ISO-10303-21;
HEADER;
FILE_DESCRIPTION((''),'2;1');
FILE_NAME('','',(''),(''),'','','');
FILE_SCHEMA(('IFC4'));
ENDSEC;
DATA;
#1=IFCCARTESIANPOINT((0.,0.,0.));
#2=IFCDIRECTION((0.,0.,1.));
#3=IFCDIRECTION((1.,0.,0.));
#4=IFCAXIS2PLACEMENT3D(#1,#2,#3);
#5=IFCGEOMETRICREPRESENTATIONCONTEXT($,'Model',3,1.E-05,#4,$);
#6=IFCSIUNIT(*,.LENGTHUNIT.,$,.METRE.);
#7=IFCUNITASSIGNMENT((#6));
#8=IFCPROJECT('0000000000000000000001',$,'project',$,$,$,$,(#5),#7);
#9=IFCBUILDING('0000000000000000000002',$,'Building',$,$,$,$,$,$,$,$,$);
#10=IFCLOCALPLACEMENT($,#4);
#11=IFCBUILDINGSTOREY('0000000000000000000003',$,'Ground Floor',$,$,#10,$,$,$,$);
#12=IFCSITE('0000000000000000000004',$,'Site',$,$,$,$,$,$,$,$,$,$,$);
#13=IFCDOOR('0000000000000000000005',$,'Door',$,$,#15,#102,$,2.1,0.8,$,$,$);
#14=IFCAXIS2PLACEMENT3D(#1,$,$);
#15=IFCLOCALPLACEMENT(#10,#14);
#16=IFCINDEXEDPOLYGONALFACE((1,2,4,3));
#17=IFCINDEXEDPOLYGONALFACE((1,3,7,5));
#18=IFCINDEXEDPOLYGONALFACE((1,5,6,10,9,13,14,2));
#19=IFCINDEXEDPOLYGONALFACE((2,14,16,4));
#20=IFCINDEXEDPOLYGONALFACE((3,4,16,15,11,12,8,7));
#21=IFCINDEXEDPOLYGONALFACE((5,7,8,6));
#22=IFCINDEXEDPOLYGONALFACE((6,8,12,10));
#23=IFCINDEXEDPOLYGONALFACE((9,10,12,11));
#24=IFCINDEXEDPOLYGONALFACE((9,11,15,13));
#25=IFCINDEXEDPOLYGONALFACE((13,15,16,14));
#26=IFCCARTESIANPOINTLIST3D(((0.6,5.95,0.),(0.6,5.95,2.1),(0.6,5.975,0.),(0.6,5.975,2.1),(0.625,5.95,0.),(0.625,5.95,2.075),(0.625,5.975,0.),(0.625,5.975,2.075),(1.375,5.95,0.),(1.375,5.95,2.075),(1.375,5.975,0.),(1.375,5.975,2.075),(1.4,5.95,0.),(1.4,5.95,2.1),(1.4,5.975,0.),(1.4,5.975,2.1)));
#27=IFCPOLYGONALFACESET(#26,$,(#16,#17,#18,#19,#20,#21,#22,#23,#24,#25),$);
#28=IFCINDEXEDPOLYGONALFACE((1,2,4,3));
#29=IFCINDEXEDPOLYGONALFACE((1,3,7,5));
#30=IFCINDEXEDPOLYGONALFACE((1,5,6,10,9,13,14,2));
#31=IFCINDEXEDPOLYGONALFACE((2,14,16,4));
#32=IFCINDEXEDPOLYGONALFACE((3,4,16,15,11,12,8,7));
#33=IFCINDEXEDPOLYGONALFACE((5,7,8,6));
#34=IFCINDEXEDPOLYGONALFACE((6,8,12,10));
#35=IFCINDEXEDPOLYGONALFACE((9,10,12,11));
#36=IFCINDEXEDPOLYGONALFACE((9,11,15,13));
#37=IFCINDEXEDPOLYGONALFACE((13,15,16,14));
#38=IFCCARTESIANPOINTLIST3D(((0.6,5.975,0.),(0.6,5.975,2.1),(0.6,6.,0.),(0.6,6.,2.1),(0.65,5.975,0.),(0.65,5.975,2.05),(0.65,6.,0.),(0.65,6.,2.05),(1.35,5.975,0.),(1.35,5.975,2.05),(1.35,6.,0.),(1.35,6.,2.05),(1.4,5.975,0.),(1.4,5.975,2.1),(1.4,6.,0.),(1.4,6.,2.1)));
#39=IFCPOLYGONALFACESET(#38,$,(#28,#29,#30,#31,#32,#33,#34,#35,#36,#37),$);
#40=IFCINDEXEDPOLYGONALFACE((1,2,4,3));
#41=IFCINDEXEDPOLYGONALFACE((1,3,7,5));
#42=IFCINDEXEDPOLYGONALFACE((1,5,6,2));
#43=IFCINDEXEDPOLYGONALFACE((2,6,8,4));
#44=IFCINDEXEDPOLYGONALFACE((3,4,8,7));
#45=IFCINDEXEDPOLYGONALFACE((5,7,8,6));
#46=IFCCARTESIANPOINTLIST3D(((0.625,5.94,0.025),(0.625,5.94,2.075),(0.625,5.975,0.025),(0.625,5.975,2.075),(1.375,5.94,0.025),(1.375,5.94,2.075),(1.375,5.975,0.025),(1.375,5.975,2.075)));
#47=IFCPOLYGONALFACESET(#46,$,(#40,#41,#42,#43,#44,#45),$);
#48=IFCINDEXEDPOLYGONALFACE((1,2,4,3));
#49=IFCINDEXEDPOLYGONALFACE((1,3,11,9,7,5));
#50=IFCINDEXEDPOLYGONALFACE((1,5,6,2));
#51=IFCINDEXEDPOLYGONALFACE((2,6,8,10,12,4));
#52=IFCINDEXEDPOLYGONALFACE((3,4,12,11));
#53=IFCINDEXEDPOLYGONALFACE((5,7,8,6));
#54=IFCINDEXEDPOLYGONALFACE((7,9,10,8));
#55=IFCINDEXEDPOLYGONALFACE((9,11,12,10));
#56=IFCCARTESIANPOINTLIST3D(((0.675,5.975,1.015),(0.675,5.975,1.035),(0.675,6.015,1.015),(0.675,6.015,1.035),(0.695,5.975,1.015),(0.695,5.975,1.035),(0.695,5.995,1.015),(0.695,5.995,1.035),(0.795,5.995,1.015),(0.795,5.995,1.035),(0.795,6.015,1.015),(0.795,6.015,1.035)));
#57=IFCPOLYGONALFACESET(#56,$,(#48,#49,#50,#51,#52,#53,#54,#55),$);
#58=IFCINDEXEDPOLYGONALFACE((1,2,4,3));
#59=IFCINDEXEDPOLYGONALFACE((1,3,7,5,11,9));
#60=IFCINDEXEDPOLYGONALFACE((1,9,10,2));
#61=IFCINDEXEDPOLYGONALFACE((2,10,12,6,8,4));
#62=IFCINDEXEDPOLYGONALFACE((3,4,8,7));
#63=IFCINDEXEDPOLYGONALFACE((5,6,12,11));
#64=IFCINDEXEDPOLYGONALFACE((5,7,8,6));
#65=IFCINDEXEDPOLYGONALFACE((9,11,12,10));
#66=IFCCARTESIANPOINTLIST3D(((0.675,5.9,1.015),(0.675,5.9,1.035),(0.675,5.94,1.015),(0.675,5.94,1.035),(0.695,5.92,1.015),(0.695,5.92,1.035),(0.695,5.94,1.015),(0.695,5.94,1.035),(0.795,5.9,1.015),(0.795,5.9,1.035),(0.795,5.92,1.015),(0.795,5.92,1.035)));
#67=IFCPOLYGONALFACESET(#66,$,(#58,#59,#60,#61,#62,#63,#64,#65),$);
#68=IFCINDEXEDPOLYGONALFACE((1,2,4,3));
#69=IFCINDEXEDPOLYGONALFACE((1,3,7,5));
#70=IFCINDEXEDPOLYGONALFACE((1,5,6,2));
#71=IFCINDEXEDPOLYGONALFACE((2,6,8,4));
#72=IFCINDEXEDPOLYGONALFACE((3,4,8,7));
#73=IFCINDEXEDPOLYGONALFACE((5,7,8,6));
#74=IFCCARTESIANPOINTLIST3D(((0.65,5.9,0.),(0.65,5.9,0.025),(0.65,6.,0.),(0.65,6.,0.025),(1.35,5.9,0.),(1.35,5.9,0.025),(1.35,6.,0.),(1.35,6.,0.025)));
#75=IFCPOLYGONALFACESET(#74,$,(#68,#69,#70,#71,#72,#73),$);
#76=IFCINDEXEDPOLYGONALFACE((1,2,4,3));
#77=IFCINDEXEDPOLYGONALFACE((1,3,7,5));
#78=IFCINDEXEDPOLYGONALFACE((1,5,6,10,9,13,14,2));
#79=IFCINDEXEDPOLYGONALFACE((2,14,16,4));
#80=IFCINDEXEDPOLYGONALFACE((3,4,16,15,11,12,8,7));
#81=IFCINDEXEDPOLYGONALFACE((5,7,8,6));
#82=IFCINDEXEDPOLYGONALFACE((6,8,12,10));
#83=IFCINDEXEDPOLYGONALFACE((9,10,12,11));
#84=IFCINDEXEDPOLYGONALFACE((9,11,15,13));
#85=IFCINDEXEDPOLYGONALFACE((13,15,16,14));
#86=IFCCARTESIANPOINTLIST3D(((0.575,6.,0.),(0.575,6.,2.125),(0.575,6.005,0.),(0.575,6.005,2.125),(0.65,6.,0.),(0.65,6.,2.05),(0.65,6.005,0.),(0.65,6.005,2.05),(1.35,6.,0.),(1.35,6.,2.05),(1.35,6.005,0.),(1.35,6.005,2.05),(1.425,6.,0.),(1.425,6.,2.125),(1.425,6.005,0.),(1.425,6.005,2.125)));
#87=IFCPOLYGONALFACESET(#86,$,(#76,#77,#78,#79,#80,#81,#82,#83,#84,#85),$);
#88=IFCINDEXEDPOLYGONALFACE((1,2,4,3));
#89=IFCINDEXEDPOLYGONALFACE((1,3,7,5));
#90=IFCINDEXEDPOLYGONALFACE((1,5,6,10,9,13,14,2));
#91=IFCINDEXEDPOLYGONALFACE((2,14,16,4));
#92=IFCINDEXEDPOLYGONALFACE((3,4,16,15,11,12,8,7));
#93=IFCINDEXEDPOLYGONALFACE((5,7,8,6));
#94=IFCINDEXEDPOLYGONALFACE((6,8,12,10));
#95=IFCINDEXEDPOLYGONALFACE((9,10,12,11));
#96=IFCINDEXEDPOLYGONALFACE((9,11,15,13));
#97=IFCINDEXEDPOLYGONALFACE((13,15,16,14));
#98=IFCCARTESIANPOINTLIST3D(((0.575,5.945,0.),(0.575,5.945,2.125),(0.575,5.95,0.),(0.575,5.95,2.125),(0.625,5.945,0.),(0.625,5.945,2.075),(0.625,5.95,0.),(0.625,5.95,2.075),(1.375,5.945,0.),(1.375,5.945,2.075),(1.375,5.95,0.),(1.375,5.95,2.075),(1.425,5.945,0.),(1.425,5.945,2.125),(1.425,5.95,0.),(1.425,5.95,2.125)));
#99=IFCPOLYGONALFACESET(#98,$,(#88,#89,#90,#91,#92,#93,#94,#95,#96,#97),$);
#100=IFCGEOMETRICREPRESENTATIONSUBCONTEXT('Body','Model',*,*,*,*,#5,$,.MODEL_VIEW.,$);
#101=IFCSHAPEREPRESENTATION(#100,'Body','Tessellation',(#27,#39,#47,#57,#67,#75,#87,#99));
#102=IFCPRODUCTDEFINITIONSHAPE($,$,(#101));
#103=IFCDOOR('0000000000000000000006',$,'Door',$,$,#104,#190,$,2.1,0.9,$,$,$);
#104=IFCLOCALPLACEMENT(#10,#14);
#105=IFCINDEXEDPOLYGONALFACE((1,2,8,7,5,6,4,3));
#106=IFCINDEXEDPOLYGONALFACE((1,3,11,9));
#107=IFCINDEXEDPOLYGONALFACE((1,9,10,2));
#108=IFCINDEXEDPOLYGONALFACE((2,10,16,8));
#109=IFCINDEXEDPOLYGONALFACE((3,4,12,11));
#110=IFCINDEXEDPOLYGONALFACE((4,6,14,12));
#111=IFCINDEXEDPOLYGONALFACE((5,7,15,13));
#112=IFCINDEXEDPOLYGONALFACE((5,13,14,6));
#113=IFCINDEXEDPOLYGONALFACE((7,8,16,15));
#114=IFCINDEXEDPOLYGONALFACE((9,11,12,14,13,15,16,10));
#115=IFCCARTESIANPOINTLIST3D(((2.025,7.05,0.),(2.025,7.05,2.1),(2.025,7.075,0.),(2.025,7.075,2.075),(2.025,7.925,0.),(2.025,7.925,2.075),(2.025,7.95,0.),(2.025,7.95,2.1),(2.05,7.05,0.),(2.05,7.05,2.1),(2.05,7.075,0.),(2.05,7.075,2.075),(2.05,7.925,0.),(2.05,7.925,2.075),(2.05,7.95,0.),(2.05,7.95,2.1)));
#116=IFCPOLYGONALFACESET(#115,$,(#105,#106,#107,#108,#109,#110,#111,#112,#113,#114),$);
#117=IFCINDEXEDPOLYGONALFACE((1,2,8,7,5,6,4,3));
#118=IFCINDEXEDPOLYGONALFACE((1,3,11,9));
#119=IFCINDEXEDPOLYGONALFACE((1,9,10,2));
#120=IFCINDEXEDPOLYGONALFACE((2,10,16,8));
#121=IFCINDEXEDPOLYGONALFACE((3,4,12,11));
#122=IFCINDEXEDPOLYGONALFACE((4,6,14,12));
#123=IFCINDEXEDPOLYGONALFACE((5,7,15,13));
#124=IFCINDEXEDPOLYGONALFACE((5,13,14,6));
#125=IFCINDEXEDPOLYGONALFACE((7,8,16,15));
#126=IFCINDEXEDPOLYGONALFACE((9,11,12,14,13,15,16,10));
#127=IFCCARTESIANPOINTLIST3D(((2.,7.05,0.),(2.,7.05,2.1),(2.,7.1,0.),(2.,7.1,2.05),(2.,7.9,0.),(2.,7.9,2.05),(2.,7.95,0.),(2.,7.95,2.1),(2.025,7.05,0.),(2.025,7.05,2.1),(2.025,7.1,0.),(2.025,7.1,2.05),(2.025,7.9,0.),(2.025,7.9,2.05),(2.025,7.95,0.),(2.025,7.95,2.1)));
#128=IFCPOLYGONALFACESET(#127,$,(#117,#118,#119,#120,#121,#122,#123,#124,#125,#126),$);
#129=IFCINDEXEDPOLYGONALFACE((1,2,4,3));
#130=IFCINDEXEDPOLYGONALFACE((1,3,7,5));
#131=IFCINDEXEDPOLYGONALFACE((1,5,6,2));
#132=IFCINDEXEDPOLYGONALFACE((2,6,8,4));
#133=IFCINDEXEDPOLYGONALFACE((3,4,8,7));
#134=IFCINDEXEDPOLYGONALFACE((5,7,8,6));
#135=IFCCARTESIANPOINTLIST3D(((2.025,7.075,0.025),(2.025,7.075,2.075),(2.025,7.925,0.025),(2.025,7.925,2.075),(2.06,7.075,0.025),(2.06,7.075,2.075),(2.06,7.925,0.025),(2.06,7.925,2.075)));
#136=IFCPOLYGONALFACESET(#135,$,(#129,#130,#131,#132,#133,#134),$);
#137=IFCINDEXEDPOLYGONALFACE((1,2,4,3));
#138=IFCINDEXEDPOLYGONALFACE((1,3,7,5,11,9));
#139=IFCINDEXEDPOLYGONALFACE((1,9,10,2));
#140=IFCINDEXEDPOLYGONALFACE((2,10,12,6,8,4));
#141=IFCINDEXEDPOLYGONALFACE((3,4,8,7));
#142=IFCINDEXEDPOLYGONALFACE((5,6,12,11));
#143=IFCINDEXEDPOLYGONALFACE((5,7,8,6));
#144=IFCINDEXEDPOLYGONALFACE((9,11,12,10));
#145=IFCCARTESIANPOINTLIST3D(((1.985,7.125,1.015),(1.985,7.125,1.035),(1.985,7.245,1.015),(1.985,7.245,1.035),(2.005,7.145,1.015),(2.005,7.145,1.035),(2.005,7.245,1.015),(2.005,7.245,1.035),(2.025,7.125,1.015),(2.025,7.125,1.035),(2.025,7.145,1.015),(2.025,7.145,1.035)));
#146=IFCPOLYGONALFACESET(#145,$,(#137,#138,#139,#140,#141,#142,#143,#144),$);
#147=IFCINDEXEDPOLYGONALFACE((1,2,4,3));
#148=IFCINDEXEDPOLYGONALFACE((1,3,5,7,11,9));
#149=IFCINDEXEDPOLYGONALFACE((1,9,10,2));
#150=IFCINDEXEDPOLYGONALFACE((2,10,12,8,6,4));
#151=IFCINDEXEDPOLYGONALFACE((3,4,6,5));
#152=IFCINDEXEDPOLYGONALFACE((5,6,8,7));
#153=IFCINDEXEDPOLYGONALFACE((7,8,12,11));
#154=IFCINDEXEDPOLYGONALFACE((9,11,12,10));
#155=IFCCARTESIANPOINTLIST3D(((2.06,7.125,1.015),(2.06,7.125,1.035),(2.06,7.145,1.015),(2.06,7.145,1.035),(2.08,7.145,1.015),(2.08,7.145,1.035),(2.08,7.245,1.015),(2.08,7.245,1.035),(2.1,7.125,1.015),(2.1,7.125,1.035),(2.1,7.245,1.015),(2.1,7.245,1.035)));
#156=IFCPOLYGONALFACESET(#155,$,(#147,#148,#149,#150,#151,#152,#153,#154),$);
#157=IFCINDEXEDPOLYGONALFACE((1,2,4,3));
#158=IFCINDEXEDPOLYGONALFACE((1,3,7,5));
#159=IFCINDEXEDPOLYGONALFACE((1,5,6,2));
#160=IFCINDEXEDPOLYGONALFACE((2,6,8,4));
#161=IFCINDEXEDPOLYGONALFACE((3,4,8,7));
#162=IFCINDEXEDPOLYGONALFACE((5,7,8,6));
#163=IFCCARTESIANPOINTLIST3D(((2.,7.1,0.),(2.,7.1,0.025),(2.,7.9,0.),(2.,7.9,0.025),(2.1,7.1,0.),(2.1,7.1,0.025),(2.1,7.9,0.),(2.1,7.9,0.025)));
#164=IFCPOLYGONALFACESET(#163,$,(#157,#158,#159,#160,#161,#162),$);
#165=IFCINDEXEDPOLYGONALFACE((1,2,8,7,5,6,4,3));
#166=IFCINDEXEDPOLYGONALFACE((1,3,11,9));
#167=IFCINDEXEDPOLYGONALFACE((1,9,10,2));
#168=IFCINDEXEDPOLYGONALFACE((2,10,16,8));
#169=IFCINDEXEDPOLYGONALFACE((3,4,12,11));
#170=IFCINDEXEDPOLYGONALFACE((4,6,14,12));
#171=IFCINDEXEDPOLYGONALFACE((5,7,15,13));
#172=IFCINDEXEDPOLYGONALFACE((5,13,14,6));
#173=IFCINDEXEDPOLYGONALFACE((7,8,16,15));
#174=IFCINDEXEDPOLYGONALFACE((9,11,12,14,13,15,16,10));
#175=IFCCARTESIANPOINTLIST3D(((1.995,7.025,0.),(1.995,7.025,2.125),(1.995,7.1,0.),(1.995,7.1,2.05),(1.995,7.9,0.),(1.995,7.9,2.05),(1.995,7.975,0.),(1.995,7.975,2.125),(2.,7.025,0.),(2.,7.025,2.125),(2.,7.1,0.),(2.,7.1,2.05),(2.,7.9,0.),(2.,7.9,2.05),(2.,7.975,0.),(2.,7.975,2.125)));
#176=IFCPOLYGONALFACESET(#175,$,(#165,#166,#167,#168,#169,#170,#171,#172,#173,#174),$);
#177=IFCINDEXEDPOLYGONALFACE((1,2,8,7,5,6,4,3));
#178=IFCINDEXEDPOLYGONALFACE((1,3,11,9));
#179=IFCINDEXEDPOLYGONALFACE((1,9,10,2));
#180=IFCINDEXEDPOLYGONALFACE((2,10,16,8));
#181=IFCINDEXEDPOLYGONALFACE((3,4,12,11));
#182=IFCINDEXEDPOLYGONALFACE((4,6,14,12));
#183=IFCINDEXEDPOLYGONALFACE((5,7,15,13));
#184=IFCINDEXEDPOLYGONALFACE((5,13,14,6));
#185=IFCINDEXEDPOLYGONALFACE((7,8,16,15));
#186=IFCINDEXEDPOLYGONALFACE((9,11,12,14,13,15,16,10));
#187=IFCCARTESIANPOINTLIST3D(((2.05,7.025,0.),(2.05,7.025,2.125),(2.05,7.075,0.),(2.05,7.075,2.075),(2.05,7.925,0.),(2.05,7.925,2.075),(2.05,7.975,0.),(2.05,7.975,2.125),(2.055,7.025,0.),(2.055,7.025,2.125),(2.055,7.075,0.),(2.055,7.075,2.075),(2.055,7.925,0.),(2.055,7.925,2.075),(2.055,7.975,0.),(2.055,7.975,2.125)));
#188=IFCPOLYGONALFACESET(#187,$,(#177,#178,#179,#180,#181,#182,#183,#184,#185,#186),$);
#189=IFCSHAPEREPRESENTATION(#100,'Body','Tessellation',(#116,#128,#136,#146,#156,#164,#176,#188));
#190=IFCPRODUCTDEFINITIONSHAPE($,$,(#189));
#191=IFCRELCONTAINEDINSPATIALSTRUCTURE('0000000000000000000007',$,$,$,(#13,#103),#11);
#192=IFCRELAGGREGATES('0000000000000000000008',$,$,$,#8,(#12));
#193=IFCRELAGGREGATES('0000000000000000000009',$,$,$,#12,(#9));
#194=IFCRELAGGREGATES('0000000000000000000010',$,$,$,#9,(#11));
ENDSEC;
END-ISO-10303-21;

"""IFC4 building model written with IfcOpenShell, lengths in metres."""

from ifc_helpers import new_model, si_unit, frame, origin_with_axes, place, context, subcontext, project, spatial, line, indexed_curve, outline, extrude, element, save


model = new_model("IFC4")

# Units and contexts
model_context = context("Model", 3, precision=1e-05, world=origin_with_axes())
body_context = subcontext(model_context, "Body", "Model", "MODEL_VIEW")
ifc_project = project(units=[si_unit("LENGTHUNIT", "METRE")], contexts=[model_context])

# Site, building, storey
site = spatial("IfcSite", under=ifc_project, Name="Site")
building = spatial("IfcBuilding", under=site, Name="Building")
storey_placement = place(None, origin_with_axes())
storey = spatial("IfcBuildingStorey", under=building, at=storey_placement, Name="Ground Floor")

# Doors
door_1_placement = place(storey_placement, frame((1.4, 6.0, 0.0), z_axis=(0.0, 0.0, 1.0), x_axis=(-1.0, 0.0, 0.0)))
element("IfcDoor", 1, at=door_1_placement, inside=storey, Name="Door", OverallHeight=2.1, OverallWidth=0.8, context=body_context, shape_type="SweptSolid", body=[
    extrude(outline(indexed_curve([(0.0, 0.0), (0.0, 2.1), (0.8, 2.1), (0.8, 0.0), (0.775, 0.0), (0.775, 2.075), (0.025, 2.075), (0.025, 0.0)], segments=[line(1, 2, 3, 4, 5, 6, 7, 8, 1)])), frame((0.0, 0.025, 0.0), z_axis=(0.0, -1.0, 0.0), x_axis=(1.0, 0.0, 0.0)), (0.0, 0.0, -1.0), 0.025),
    extrude(outline(indexed_curve([(0.0, 0.0), (0.0, 2.1), (0.8, 2.1), (0.8, 0.0), (0.75, 0.0), (0.75, 2.05), (0.05, 2.05), (0.05, 0.0)], segments=[line(1, 2, 3, 4, 5, 6, 7, 8, 1)])), frame((0.0, 0.0, 0.0), z_axis=(0.0, -1.0, 0.0), x_axis=(1.0, 0.0, 0.0)), (0.0, 0.0, -1.0), 0.025),
    extrude(outline(indexed_curve([(0.0, 0.0), (0.75, 0.0), (0.75, 0.035), (0.0, 0.035)], segments=[line(1, 2, 3, 4, 1)])), frame((0.025, 0.025, 0.025), z_axis=(0.0, 0.0, 1.0), x_axis=(1.0, 0.0, 0.0)), (0.0, 0.0, 1.0), 2.05),
    extrude(outline(indexed_curve([(0.0, 0.0), (0.0, -0.04), (-0.12, -0.04), (-0.12, -0.02), (-0.02, -0.02), (-0.02, 0.0)], segments=[line(1, 2, 3, 4, 5, 6, 1)])), frame((0.725, 0.025, 1.015), z_axis=(0.0, 0.0, 1.0), x_axis=(1.0, 0.0, 0.0)), (0.0, 0.0, 1.0), 0.02),
    extrude(outline(indexed_curve([(0.0, 0.0), (0.0, 0.04), (-0.12, 0.04), (-0.12, 0.02), (-0.02, 0.02), (-0.02, 0.0)], segments=[line(1, 2, 3, 4, 5, 6, 1)])), frame((0.725, 0.06, 1.015), z_axis=(0.0, 0.0, 1.0), x_axis=(1.0, 0.0, 0.0)), (0.0, 0.0, 1.0), 0.02),
    extrude(outline(indexed_curve([(0.0, 0.0), (0.7, 0.0), (0.7, 0.1), (0.0, 0.1)], segments=[line(1, 2, 3, 4, 1)])), frame((0.05, 0.0, 0.0), z_axis=(0.0, 0.0, 1.0), x_axis=(1.0, 0.0, 0.0)), (0.0, 0.0, 1.0), 0.025),
    extrude(outline(indexed_curve([(0.0, 0.0), (0.0, 2.125), (0.85, 2.125), (0.85, 0.0), (0.775, 0.0), (0.775, 2.05), (0.075, 2.05), (0.075, 0.0)], segments=[line(1, 2, 3, 4, 5, 6, 7, 8, 1)])), frame((-0.025, -0.005, 0.0), z_axis=(0.0, -1.0, 0.0), x_axis=(1.0, 0.0, 0.0)), (0.0, 0.0, -1.0), 0.005),
    extrude(outline(indexed_curve([(0.0, 0.0), (0.0, 2.125), (0.85, 2.125), (0.85, 0.0), (0.8, 0.0), (0.8, 2.075), (0.05, 2.075), (0.05, 0.0)], segments=[line(1, 2, 3, 4, 5, 6, 7, 8, 1)])), frame((-0.025, 0.05, 0.0), z_axis=(0.0, -1.0, 0.0), x_axis=(1.0, 0.0, 0.0)), (0.0, 0.0, -1.0), 0.005),
])
door_2_placement = place(storey_placement, frame((2.0, 7.95, 0.0), z_axis=(0.0, 0.0, 1.0), x_axis=(0.0, -1.0, 0.0)))
element("IfcDoor", 2, at=door_2_placement, inside=storey, Name="Door", OverallHeight=2.1, OverallWidth=0.9, context=body_context, shape_type="SweptSolid", body=[
    extrude(outline(indexed_curve([(0.0, 0.0), (0.0, 2.1), (0.9, 2.1), (0.9, 0.0), (0.875, 0.0), (0.875, 2.075), (0.025, 2.075), (0.025, 0.0)], segments=[line(1, 2, 3, 4, 5, 6, 7, 8, 1)])), frame((0.0, 0.025, 0.0), z_axis=(0.0, -1.0, 0.0), x_axis=(1.0, 0.0, 0.0)), (0.0, 0.0, -1.0), 0.025),
    extrude(outline(indexed_curve([(0.0, 0.0), (0.0, 2.1), (0.9, 2.1), (0.9, 0.0), (0.85, 0.0), (0.85, 2.05), (0.05, 2.05), (0.05, 0.0)], segments=[line(1, 2, 3, 4, 5, 6, 7, 8, 1)])), frame((0.0, 0.0, 0.0), z_axis=(0.0, -1.0, 0.0), x_axis=(1.0, 0.0, 0.0)), (0.0, 0.0, -1.0), 0.025),
    extrude(outline(indexed_curve([(0.0, 0.0), (0.85, 0.0), (0.85, 0.035), (0.0, 0.035)], segments=[line(1, 2, 3, 4, 1)])), frame((0.025, 0.025, 0.025), z_axis=(0.0, 0.0, 1.0), x_axis=(1.0, 0.0, 0.0)), (0.0, 0.0, 1.0), 2.05),
    extrude(outline(indexed_curve([(0.0, 0.0), (0.0, -0.04), (-0.12, -0.04), (-0.12, -0.02), (-0.02, -0.02), (-0.02, 0.0)], segments=[line(1, 2, 3, 4, 5, 6, 1)])), frame((0.825, 0.025, 1.015), z_axis=(0.0, 0.0, 1.0), x_axis=(1.0, 0.0, 0.0)), (0.0, 0.0, 1.0), 0.02),
    extrude(outline(indexed_curve([(0.0, 0.0), (0.0, 0.04), (-0.12, 0.04), (-0.12, 0.02), (-0.02, 0.02), (-0.02, 0.0)], segments=[line(1, 2, 3, 4, 5, 6, 1)])), frame((0.825, 0.06, 1.015), z_axis=(0.0, 0.0, 1.0), x_axis=(1.0, 0.0, 0.0)), (0.0, 0.0, 1.0), 0.02),
    extrude(outline(indexed_curve([(0.0, 0.0), (0.8, 0.0), (0.8, 0.1), (0.0, 0.1)], segments=[line(1, 2, 3, 4, 1)])), frame((0.05, 0.0, 0.0), z_axis=(0.0, 0.0, 1.0), x_axis=(1.0, 0.0, 0.0)), (0.0, 0.0, 1.0), 0.025),
    extrude(outline(indexed_curve([(0.0, 0.0), (0.0, 2.125), (0.95, 2.125), (0.95, 0.0), (0.875, 0.0), (0.875, 2.05), (0.075, 2.05), (0.075, 0.0)], segments=[line(1, 2, 3, 4, 5, 6, 7, 8, 1)])), frame((-0.025, -0.005, 0.0), z_axis=(0.0, -1.0, 0.0), x_axis=(1.0, 0.0, 0.0)), (0.0, 0.0, -1.0), 0.005),
    extrude(outline(indexed_curve([(0.0, 0.0), (0.0, 2.125), (0.95, 2.125), (0.95, 0.0), (0.9, 0.0), (0.9, 2.075), (0.05, 2.075), (0.05, 0.0)], segments=[line(1, 2, 3, 4, 5, 6, 7, 8, 1)])), frame((-0.025, 0.05, 0.0), z_axis=(0.0, -1.0, 0.0), x_axis=(1.0, 0.0, 0.0)), (0.0, 0.0, -1.0), 0.005),
])

save(model, "model.ifc")
